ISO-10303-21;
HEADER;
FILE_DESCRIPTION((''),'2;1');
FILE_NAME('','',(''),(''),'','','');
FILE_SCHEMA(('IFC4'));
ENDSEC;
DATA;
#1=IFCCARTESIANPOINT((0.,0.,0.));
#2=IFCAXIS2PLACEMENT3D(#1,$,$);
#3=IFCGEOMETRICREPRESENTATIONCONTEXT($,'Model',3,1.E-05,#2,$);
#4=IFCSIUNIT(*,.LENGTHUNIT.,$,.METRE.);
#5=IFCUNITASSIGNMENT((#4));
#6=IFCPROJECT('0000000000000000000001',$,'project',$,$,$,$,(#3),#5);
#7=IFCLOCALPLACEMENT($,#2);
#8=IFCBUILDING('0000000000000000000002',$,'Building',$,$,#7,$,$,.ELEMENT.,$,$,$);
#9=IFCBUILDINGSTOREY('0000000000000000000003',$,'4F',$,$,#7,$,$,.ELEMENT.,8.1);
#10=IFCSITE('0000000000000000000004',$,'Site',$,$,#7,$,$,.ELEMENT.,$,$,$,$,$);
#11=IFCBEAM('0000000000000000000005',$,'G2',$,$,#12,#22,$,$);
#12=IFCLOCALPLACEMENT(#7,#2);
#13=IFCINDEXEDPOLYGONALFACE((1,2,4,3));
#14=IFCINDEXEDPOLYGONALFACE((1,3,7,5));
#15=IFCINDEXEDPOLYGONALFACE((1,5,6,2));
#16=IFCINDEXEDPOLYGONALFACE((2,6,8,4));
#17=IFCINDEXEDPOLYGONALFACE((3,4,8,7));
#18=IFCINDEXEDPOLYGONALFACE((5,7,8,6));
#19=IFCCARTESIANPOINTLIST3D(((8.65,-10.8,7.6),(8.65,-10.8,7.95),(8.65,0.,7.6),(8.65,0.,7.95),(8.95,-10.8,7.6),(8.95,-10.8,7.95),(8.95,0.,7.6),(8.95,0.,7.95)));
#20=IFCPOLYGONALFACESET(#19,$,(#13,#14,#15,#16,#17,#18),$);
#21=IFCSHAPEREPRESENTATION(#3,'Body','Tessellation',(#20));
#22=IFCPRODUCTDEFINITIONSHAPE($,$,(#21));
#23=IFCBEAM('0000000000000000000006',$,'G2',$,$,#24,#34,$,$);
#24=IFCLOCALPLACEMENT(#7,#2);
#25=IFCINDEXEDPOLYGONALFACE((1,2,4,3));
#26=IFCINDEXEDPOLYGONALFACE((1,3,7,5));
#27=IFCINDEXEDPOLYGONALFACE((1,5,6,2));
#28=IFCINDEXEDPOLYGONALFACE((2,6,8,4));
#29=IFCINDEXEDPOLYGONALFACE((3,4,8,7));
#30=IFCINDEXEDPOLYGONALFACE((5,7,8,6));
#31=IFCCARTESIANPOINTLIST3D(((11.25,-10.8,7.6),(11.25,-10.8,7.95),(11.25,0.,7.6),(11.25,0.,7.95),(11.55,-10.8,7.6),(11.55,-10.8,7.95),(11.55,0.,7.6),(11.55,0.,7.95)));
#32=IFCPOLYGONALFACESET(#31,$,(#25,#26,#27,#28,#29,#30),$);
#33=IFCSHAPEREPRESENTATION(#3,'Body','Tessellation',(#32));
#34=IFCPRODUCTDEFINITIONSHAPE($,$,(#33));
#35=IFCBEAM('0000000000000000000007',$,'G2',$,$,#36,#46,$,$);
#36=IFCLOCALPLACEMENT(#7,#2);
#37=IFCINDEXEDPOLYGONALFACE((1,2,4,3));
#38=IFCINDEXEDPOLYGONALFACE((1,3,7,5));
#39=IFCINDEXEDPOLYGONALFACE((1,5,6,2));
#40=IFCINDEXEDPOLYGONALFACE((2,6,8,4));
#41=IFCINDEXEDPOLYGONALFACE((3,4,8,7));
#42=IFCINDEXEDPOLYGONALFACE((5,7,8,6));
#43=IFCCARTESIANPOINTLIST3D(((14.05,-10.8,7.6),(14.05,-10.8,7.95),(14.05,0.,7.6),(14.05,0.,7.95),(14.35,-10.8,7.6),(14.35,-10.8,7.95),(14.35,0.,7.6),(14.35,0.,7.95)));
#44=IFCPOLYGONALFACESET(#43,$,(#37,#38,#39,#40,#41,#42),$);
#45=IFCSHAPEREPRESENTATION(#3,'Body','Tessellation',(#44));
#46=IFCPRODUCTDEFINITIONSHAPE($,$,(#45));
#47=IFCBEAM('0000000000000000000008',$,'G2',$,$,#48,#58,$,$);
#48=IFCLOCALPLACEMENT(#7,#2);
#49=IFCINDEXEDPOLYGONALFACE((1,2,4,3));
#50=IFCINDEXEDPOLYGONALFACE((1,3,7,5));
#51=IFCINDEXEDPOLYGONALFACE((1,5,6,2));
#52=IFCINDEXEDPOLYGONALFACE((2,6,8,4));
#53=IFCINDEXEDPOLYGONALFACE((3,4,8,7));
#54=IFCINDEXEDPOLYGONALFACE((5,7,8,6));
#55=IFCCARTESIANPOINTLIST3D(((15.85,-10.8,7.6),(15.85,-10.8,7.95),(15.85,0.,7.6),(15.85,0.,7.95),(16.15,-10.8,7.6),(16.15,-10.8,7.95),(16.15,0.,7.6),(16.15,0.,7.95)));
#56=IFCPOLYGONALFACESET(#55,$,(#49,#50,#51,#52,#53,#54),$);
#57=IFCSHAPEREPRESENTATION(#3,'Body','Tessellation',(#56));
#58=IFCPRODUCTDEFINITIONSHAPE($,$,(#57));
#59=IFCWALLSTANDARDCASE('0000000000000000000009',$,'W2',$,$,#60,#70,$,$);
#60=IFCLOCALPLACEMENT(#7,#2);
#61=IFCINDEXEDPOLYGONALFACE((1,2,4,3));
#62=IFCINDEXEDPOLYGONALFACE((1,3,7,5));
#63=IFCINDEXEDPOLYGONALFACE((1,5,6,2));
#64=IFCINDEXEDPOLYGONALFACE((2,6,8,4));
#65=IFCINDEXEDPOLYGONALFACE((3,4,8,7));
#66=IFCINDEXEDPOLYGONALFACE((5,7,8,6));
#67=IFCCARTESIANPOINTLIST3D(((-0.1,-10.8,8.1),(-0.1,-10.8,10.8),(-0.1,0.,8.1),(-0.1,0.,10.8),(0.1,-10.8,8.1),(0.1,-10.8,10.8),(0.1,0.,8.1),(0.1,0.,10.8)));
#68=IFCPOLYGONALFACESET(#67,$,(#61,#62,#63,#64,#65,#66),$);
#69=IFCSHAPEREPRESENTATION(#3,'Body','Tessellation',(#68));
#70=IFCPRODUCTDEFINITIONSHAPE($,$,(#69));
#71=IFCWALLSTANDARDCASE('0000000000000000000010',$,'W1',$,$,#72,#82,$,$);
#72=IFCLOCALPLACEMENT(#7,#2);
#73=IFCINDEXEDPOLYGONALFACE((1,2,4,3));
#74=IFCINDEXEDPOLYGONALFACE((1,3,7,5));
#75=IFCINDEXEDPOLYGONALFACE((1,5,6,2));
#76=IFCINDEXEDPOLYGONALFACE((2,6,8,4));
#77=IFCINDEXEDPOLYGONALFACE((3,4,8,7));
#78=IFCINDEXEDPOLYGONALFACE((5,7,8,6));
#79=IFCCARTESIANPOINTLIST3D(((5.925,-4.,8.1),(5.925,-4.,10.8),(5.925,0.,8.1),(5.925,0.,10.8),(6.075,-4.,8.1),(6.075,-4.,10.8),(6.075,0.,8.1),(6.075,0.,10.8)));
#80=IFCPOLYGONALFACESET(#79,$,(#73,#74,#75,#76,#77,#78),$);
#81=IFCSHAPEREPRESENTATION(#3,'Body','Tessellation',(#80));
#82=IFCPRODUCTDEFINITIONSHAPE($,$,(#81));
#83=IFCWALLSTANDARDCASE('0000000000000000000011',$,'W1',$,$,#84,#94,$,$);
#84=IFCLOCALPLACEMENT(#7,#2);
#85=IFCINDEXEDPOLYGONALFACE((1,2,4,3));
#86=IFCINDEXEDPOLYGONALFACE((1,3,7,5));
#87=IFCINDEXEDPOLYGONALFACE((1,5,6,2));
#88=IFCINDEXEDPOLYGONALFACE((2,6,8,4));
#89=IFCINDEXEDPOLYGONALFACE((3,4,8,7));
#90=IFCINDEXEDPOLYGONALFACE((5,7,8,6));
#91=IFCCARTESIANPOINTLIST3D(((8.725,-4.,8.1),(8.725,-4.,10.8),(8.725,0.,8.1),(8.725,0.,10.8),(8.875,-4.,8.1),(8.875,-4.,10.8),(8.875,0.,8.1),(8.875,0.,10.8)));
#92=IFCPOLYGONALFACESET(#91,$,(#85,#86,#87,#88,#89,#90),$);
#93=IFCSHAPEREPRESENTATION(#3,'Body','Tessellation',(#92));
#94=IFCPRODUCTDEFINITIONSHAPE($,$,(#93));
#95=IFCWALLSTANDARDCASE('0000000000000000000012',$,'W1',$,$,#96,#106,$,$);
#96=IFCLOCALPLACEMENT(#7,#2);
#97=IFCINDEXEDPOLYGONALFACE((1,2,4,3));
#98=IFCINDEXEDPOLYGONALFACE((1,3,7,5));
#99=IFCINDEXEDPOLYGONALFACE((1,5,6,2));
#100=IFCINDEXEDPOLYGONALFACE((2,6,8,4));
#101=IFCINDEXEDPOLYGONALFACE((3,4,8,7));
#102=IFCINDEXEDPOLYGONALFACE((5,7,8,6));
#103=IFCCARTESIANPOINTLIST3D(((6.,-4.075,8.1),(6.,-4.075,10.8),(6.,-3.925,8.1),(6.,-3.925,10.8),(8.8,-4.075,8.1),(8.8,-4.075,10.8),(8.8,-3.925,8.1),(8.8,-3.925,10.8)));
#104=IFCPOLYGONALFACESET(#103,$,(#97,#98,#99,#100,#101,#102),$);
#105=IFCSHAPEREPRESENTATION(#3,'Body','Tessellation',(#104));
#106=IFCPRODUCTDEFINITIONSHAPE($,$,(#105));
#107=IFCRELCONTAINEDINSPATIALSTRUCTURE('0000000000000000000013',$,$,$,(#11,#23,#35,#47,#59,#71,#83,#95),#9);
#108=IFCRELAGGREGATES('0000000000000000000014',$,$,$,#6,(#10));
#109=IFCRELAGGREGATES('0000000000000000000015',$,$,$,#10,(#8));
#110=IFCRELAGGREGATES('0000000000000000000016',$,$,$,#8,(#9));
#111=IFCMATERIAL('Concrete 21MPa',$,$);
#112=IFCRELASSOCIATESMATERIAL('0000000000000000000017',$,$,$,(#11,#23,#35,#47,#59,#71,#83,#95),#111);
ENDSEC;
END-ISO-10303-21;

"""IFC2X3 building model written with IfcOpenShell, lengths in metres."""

from ifc_helpers import new_model, si_unit, frame, origin, origin_2d, place, context, project, spatial, rectangle, extrude, material, element, save


model = new_model("IFC2X3")

# Units and contexts
model_context = context("Model", 3, precision=1e-05, world=origin())
ifc_project = project(units=[si_unit("LENGTHUNIT", "METRE")], contexts=[model_context])

# Site, building, storey
placement = place(None, origin())
site = spatial("IfcSite", under=ifc_project, at=placement, Name="Site", CompositionType="ELEMENT")
building = spatial("IfcBuilding", under=site, at=placement, Name="Building", CompositionType="ELEMENT")
storey = spatial("IfcBuildingStorey", under=building, at=placement, Name="4F", CompositionType="ELEMENT", Elevation=8.1)

# Shared definitions
ifc_material = material(Name="Concrete 21MPa")

# Beams
for number, where, name in (
    (1, (8.8, -5.4, 7.6), "G2"),
    (2, (11.4, -5.4, 7.6), "G2"),
    (3, (14.2, -5.4, 7.6), "G2"),
    (4, (16.0, -5.4, 7.6), "G2"),
):
    element("IfcBeam", number, at=place(None, frame(where)), inside=storey, material=ifc_material, Name=name, context=model_context, shape_type="SweptSolid", body=[
        extrude(rectangle(XDim=0.3, YDim=10.8, at=origin_2d()), origin(), (0.0, 0.0, 1.0), 0.35),
    ])

# Walls
wall_1_placement = place(None, frame((0.0, -5.4, 8.1)))
element("IfcWallStandardCase", 5, at=wall_1_placement, inside=storey, material=ifc_material, Name="W2", context=model_context, shape_type="SweptSolid", body=[
    extrude(rectangle(XDim=0.2, YDim=10.8, at=origin_2d()), origin(), (0.0, 0.0, 1.0), 2.7),
])
for number, where, name in (
    (6, (6.0, -2.0, 8.1), "W1"),
    (7, (8.8, -2.0, 8.1), "W1"),
):
    element("IfcWallStandardCase", number, at=place(None, frame(where)), inside=storey, material=ifc_material, Name=name, context=model_context, shape_type="SweptSolid", body=[
        extrude(rectangle(XDim=0.15, YDim=4.0, at=origin_2d()), origin(), (0.0, 0.0, 1.0), 2.7),
    ])
wall_2_placement = place(None, frame((7.4, -4.0, 8.1)))
element("IfcWallStandardCase", 8, at=wall_2_placement, inside=storey, material=ifc_material, Name="W1", context=model_context, shape_type="SweptSolid", body=[
    extrude(rectangle(XDim=2.8, YDim=0.15, at=origin_2d()), origin(), (0.0, 0.0, 1.0), 2.7),
])

save(model, "model.ifc")
